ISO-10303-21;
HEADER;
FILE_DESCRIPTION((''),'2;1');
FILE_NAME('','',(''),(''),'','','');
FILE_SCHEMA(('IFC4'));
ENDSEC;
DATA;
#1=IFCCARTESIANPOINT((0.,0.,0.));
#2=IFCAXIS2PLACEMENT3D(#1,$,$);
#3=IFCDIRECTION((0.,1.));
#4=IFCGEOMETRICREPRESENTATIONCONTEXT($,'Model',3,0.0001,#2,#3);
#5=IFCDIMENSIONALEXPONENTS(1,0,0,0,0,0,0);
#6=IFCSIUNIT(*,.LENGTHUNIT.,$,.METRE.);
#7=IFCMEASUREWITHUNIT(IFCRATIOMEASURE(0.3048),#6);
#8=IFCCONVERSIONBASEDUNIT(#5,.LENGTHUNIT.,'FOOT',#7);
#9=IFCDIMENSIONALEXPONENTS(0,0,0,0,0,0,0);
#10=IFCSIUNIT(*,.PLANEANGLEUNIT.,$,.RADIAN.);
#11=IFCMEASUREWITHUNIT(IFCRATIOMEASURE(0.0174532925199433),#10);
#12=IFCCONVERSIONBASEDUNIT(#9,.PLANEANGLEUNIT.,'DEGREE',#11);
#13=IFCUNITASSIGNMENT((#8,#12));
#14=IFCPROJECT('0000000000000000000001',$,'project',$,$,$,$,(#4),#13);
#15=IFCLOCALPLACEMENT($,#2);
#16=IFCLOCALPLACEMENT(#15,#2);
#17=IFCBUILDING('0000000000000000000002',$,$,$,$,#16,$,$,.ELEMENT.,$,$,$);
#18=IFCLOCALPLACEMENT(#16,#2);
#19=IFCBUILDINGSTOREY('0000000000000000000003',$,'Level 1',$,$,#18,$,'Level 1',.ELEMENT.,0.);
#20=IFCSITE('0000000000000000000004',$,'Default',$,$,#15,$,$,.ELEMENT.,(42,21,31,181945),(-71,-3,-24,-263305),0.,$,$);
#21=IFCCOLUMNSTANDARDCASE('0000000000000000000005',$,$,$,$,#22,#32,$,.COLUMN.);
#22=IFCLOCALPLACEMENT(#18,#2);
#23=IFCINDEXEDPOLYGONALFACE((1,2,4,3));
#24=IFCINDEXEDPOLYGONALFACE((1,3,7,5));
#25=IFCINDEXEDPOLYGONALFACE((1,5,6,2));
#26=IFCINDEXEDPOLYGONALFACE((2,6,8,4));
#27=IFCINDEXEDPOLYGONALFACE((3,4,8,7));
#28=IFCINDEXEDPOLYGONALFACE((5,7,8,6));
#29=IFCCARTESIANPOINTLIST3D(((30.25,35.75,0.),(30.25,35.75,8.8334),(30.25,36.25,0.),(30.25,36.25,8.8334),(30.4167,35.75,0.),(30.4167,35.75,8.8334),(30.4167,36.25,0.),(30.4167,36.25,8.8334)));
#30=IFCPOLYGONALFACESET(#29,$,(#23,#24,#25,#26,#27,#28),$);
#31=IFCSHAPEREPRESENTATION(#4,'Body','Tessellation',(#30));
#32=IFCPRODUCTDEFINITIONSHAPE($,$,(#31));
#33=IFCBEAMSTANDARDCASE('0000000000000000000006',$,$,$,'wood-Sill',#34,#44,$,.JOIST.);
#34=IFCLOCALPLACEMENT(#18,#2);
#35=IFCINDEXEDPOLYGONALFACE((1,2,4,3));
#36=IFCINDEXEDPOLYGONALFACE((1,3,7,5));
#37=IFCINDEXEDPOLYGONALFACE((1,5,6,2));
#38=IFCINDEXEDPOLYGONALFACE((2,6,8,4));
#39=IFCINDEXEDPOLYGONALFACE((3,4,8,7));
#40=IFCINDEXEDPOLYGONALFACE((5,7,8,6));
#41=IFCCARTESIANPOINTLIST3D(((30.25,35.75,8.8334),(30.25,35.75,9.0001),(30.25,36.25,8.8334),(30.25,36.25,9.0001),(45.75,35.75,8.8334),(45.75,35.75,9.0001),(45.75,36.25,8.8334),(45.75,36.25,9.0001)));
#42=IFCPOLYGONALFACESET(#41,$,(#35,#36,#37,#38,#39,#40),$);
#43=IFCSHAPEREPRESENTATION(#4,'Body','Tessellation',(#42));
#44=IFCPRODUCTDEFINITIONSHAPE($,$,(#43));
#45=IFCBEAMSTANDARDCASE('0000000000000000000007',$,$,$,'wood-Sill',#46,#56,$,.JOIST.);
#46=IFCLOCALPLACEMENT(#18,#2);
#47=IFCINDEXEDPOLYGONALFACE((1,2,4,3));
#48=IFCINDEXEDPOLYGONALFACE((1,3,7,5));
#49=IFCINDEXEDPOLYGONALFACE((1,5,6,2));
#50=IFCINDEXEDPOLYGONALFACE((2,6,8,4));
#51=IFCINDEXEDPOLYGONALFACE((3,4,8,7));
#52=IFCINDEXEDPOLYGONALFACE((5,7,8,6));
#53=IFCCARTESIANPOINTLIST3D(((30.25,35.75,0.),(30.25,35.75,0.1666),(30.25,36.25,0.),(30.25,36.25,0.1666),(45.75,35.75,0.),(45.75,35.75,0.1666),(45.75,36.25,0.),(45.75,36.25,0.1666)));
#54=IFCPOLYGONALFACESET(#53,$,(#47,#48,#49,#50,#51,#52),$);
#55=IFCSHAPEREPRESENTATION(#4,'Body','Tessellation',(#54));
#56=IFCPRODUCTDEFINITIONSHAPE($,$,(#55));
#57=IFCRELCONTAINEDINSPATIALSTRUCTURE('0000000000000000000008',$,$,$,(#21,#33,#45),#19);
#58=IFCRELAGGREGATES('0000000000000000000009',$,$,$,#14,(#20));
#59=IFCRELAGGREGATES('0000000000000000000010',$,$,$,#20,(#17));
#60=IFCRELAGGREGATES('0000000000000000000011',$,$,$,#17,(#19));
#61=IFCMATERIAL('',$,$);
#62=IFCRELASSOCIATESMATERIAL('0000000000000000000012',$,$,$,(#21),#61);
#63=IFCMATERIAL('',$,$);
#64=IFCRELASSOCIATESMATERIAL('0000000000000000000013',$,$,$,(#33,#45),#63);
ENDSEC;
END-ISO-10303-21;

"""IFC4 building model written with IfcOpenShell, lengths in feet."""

from ifc_helpers import new_model, entity, si_unit, converted_unit, direction, frame, origin, origin_with_axes, place, context, project, spatial, rectangle, extrude, material, element, save


model = new_model("IFC4")

# Units and contexts
model_context = context("Model", 3, precision=0.0001, world=origin(), true_north=direction((0.0, 1.0)))
ifc_project = project(units=[converted_unit("LENGTHUNIT", "FOOT", entity("IfcRatioMeasure", 0.3048), si_unit("LENGTHUNIT", "METRE"), dimensions=[1, 0, 0, 0, 0, 0, 0]), converted_unit("PLANEANGLEUNIT", "DEGREE", entity("IfcRatioMeasure", 0.0174532925199433), si_unit("PLANEANGLEUNIT", "RADIAN"), dimensions=[0, 0, 0, 0, 0, 0, 0])], contexts=[model_context])

# Site, building, storey
site_placement = place(None, origin())
site = spatial("IfcSite", under=ifc_project, at=site_placement, Name="Default", CompositionType="ELEMENT", RefLatitude=(42, 21, 31, 181945), RefLongitude=(-71, -3, -24, -263305), RefElevation=0.0)
building_placement = place(site_placement, origin())
building = spatial("IfcBuilding", under=site, at=building_placement, CompositionType="ELEMENT")
storey_placement = place(building_placement, origin())
storey = spatial("IfcBuildingStorey", under=building, at=storey_placement, Name="Level 1", LongName="Level 1", CompositionType="ELEMENT", Elevation=0.0)

# Column
ifc_material_1 = material(Name="")
placement_1 = place(storey_placement, frame((30.25, 36.0, 0.0)))
for number, where, z_axis, x_axis in (
    (1, (0.0833, 0.0, 0.0), (0.0, 0.0, 1.0), (1.0, 0.0, 0.0)),
):
    element("IfcColumnStandardCase", number, at=place(placement_1, frame(where, z_axis=z_axis, x_axis=x_axis)), inside=storey, material=ifc_material_1, PredefinedType="COLUMN", context=model_context, shape_type="SweptSolid", body=[
        extrude(rectangle(XDim=0.1667, YDim=0.5), origin(), (0.0, 0.0, 1.0), 8.8334),
    ])

# Beams
ifc_material_2 = material(Name="")
for number, where, z_axis, x_axis in (
    (2, (0.0, 0.0, 8.9167), (1.0, 0.0, 0.0), (0.0, 0.0, 1.0)),
    (3, (0.0, 0.0, 0.0833), (1.0, 0.0, 0.0), (0.0, 0.0, 1.0)),
):
    element("IfcBeamStandardCase", number, at=place(placement_1, frame(where, z_axis=z_axis, x_axis=x_axis)), inside=storey, material=ifc_material_2, ObjectType="wood-Sill", PredefinedType="JOIST", context=model_context, shape_type="SweptSolid", body=[
        extrude(rectangle(XDim=0.1667, YDim=0.5), origin_with_axes(), (0.0, 0.0, 1.0), 15.5),
    ])

save(model, "model.ifc")
